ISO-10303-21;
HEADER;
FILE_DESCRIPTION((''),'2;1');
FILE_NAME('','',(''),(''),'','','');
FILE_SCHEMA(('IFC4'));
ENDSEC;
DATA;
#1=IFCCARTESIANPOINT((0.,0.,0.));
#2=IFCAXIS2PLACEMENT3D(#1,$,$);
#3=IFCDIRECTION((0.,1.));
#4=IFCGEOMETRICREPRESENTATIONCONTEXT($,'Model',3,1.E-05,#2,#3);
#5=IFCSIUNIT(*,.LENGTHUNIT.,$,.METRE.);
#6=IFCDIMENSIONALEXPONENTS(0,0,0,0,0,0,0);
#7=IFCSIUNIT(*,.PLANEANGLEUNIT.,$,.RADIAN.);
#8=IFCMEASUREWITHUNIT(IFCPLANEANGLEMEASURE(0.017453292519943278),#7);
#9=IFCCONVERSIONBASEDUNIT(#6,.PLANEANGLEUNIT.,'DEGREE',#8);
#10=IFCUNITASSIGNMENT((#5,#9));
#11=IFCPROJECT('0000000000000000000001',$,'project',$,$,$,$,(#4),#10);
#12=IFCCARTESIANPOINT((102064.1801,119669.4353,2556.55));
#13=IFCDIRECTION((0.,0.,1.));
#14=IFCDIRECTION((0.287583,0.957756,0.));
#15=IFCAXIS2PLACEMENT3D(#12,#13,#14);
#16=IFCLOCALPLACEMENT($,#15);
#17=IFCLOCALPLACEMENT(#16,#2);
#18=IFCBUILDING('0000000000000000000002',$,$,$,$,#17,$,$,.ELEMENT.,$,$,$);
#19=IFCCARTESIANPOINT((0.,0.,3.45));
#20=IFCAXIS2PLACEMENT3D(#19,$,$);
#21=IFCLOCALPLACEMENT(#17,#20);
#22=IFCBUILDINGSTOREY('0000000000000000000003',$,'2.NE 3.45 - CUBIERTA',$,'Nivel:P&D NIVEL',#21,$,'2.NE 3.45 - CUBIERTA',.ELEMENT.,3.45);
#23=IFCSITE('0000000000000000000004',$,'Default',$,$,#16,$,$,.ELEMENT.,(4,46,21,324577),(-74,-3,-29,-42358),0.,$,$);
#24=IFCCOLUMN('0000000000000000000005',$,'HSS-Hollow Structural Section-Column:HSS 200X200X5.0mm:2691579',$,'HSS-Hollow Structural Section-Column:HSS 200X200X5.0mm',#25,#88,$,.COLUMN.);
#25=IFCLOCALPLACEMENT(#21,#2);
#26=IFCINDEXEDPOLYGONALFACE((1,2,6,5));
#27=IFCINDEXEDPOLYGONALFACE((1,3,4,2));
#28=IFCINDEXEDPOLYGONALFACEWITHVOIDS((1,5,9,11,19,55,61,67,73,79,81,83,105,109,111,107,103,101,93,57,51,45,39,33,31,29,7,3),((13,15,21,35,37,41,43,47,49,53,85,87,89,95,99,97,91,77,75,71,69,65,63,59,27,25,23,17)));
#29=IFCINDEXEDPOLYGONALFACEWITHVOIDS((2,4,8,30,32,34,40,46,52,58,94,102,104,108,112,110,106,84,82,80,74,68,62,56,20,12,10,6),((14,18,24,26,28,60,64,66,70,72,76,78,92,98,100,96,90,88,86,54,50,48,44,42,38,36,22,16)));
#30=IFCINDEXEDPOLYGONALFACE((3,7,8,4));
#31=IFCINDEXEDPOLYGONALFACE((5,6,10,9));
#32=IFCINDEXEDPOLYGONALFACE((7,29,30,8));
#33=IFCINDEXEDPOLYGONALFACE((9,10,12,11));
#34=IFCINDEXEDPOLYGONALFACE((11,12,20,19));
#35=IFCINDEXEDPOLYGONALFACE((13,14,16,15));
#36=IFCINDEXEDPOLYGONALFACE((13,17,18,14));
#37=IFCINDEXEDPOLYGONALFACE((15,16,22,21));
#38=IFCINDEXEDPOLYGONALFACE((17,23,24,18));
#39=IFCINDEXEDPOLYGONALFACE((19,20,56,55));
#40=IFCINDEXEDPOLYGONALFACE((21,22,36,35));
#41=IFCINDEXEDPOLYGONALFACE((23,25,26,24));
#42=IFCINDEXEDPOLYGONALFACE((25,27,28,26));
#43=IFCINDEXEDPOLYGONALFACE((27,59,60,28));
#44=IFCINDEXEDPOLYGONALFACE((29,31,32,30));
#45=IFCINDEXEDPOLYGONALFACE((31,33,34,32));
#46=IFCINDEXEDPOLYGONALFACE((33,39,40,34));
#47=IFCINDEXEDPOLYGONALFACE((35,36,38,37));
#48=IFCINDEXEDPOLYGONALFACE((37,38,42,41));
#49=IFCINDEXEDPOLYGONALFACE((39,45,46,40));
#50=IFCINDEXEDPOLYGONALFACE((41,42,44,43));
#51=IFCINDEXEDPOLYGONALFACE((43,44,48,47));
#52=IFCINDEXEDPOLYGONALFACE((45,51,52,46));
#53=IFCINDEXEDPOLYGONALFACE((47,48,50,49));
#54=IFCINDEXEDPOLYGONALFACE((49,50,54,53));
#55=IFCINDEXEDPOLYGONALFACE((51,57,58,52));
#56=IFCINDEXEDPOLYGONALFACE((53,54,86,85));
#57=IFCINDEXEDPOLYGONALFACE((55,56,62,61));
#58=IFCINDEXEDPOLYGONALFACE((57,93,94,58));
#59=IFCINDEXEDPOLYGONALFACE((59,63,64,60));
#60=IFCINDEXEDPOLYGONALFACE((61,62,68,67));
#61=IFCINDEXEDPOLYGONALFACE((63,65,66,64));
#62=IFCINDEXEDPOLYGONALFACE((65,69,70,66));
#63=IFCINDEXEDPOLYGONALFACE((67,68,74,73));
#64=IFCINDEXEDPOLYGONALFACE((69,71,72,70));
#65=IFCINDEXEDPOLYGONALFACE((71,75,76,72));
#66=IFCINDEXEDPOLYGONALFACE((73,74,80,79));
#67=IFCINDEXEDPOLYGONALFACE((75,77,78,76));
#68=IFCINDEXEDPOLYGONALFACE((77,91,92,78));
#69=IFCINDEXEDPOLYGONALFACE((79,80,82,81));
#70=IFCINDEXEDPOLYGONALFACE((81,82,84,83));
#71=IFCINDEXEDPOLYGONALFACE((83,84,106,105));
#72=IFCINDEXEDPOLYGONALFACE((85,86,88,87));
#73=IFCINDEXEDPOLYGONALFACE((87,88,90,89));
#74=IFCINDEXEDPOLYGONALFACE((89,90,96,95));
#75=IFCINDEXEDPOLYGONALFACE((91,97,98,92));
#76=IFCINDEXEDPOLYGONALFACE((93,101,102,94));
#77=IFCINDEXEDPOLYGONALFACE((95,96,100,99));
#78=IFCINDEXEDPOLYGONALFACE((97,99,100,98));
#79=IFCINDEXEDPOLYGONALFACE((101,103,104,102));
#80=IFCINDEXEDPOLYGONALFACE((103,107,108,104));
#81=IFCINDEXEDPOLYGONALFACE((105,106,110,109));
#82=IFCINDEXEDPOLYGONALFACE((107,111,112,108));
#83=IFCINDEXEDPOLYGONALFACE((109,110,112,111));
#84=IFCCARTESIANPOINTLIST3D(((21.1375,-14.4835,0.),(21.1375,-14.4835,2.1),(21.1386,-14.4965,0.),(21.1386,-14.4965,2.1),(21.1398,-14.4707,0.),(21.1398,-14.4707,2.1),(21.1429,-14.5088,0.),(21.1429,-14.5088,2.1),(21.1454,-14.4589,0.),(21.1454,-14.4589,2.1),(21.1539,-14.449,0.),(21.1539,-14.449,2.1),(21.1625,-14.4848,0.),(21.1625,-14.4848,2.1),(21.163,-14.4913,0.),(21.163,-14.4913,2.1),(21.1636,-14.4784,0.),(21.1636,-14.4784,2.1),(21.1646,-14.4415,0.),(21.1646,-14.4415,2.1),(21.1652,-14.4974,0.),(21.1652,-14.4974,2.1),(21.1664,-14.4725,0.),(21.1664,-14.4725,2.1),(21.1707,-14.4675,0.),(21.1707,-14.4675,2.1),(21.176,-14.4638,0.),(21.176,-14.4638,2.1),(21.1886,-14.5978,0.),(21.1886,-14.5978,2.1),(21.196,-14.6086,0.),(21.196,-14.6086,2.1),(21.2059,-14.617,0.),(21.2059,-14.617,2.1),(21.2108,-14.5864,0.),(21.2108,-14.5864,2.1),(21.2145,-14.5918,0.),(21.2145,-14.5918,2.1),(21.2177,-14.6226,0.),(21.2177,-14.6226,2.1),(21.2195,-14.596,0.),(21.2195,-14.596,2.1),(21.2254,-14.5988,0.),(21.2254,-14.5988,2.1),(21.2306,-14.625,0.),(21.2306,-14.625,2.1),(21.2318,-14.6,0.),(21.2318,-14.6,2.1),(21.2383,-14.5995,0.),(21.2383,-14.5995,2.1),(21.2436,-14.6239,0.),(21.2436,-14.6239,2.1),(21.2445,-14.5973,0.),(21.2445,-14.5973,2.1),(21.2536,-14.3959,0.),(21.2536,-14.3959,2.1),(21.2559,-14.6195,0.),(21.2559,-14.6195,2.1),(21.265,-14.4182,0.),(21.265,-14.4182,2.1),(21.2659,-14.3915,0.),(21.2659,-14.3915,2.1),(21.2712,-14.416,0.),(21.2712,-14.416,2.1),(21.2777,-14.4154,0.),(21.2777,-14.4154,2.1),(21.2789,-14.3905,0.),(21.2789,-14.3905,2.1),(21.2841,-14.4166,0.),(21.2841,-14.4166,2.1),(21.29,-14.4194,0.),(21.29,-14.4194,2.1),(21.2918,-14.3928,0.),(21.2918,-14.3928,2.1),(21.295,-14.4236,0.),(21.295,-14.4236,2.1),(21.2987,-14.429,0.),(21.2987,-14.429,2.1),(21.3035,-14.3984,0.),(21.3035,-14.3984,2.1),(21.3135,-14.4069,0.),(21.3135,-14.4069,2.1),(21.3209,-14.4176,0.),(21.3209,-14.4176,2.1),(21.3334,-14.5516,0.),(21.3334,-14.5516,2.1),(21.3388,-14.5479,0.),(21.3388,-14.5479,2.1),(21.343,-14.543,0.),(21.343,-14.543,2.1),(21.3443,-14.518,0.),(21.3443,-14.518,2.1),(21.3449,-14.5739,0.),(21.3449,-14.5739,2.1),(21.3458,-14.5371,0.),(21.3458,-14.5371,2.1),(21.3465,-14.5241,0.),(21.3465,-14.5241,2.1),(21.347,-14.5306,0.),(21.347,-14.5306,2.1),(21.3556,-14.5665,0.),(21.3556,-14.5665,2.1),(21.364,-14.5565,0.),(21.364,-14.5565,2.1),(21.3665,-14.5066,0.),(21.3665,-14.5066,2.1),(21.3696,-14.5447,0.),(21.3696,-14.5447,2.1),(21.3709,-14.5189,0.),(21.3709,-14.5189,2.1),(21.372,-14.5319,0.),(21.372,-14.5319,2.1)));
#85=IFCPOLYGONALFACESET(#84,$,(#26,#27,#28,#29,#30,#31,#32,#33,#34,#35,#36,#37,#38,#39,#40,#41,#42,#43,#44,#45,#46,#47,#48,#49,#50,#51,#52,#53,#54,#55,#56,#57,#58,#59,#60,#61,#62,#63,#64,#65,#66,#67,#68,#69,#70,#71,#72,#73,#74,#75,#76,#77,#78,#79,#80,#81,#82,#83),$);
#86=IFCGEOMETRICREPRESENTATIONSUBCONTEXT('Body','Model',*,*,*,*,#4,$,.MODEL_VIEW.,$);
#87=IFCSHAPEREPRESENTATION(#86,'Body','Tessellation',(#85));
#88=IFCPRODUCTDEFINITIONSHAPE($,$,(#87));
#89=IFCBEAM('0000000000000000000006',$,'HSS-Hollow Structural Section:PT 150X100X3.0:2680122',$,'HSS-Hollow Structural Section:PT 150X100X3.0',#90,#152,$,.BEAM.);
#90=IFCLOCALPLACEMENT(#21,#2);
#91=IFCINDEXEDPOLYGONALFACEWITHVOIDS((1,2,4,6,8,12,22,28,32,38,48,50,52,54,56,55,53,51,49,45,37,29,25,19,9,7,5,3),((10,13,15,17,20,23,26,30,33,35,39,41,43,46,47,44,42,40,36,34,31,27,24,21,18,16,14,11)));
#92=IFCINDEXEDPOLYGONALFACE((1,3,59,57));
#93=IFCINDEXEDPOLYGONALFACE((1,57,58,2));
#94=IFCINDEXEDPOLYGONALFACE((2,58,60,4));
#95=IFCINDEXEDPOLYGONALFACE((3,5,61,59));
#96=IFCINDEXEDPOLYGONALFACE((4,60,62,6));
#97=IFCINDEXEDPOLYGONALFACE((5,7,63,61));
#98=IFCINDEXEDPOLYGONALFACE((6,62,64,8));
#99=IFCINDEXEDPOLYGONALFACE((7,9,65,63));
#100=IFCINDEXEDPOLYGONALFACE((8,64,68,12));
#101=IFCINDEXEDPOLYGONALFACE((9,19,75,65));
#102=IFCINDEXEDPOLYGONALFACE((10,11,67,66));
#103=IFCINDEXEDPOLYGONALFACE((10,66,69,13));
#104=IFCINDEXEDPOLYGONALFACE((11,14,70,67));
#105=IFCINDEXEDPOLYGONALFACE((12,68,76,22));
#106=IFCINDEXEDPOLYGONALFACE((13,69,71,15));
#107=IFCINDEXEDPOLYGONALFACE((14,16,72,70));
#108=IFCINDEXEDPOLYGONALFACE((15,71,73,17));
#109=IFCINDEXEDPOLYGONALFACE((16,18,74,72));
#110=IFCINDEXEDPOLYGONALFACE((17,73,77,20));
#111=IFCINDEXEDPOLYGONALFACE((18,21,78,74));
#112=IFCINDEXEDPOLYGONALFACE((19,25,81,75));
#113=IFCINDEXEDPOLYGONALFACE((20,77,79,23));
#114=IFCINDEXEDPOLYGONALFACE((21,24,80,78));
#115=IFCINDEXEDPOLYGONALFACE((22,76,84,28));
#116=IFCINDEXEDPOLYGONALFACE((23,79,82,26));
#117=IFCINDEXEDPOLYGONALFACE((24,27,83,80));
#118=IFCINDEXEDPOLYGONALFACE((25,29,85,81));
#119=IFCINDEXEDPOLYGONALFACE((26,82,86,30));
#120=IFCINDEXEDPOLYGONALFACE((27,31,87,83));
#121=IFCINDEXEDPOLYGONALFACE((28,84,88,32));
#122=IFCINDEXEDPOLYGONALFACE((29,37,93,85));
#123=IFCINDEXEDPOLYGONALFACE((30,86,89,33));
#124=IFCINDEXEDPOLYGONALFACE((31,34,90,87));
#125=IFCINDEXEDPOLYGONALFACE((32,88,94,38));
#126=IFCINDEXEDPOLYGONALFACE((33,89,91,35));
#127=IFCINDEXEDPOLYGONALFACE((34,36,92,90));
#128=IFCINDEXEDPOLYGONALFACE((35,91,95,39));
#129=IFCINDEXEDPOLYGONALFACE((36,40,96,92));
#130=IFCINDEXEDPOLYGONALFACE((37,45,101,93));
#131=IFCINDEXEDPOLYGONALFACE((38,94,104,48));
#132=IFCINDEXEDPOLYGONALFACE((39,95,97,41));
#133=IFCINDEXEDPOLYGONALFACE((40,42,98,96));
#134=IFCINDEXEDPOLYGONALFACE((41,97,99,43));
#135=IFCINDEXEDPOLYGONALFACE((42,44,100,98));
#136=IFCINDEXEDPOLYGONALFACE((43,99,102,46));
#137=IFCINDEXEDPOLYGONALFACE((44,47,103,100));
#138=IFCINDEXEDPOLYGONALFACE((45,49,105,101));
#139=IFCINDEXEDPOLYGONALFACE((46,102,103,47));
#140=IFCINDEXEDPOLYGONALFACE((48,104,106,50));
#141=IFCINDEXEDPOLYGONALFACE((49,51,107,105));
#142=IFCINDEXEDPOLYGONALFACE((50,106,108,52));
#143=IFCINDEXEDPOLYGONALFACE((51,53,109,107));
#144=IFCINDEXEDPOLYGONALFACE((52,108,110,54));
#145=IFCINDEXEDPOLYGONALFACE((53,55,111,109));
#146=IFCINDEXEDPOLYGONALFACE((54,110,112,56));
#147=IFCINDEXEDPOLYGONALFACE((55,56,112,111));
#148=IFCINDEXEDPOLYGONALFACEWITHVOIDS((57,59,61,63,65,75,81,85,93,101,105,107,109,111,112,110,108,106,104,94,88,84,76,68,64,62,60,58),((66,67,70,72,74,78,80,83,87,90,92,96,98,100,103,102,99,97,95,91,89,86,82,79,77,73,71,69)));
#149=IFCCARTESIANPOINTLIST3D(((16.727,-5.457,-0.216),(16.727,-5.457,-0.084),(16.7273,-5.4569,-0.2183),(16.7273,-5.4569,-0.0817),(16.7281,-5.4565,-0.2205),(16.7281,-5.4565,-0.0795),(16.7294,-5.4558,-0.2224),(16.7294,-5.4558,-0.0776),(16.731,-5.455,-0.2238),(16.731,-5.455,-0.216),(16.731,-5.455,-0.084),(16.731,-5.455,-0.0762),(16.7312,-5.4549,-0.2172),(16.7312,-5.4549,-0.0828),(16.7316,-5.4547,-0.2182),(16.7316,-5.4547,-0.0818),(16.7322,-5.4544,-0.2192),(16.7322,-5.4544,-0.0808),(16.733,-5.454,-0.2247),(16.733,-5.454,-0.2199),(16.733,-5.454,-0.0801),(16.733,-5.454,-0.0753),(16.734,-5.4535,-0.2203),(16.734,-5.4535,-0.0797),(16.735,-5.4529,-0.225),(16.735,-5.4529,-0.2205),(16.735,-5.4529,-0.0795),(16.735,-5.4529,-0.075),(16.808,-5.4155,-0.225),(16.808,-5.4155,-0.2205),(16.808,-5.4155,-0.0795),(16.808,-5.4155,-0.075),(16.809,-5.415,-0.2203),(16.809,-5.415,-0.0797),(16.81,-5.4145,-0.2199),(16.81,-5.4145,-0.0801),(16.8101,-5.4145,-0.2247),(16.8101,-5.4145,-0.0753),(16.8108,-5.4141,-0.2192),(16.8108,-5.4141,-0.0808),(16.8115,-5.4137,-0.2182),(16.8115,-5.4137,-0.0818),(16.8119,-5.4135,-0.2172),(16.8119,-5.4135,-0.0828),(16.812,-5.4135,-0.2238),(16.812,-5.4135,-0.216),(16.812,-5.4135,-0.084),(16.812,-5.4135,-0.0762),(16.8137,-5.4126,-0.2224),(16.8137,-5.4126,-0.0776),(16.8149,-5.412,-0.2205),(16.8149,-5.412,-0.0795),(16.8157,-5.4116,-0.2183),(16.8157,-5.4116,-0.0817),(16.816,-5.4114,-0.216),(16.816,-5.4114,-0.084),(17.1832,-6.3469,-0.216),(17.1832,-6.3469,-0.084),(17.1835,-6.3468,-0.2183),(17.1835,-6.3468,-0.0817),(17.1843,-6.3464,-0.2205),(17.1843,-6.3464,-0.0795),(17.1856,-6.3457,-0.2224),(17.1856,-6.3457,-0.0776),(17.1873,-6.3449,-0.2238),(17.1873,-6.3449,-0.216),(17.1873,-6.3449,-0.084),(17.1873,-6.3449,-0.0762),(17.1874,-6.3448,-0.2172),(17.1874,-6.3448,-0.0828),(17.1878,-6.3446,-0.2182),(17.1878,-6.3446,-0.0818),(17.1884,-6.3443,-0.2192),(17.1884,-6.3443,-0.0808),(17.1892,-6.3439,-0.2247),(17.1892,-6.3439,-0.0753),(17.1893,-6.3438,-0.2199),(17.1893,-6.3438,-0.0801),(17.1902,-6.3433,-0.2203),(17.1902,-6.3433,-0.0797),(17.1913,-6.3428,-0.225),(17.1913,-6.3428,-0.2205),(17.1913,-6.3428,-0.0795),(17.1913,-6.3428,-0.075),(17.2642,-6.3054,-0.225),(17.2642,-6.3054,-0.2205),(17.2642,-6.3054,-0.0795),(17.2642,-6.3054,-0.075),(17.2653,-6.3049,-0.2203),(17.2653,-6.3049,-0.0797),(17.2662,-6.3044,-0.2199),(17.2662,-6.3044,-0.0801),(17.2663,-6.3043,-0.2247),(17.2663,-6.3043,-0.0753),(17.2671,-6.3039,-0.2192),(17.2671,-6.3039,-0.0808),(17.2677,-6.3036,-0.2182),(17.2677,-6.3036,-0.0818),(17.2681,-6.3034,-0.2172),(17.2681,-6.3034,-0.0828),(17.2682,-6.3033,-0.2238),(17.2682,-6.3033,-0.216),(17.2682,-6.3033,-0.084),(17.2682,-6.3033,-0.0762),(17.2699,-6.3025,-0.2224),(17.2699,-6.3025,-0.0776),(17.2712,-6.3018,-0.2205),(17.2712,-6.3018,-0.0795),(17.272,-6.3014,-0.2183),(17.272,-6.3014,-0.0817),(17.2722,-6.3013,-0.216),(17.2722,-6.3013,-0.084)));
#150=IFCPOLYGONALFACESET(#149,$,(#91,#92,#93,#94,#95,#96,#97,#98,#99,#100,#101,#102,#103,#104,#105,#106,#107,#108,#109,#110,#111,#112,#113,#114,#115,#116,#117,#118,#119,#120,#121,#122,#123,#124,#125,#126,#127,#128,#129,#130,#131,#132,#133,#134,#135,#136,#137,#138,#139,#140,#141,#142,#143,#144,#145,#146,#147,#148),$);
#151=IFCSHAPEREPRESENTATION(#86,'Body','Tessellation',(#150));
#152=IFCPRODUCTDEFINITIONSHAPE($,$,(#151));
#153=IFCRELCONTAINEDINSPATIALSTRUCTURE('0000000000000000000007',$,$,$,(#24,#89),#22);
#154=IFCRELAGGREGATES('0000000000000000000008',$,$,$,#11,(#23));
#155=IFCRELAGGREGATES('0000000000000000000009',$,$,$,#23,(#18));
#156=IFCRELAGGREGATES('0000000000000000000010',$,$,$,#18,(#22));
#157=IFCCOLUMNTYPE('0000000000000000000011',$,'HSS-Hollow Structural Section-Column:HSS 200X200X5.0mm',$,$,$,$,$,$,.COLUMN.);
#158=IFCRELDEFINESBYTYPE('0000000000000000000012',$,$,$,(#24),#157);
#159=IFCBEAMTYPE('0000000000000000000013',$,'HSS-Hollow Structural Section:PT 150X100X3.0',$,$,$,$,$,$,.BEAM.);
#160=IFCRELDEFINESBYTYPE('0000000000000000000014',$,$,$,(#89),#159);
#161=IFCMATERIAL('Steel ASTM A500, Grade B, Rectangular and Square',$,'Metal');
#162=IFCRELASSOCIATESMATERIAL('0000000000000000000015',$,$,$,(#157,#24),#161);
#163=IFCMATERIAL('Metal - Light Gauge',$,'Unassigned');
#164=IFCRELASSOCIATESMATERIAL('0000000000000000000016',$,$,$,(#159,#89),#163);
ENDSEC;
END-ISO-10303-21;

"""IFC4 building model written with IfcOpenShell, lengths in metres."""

from ifc_helpers import new_model, entity, si_unit, converted_unit, direction, frame, origin, place, context, subcontext, project, spatial, line, arc, indexed_curve, outline, extrude, source, transform, mapped, material, type_object, type_shapes, element, save


model = new_model("IFC4")

# Units and contexts
model_context = context("Model", 3, precision=1e-05, world=origin(), true_north=direction((0.0, 1.0)))
body_context = subcontext(model_context, "Body", "Model", "MODEL_VIEW")
ifc_project = project(units=[si_unit("LENGTHUNIT", "METRE"), converted_unit("PLANEANGLEUNIT", "DEGREE", entity("IfcPlaneAngleMeasure", 0.017453292519943278), si_unit("PLANEANGLEUNIT", "RADIAN"), dimensions=[0, 0, 0, 0, 0, 0, 0])], contexts=[model_context])

# Site, building, storey
site_placement = place(None, frame((102064.1801, 119669.4353, 2556.55), z_axis=(0.0, 0.0, 1.0), x_axis=(0.287583, 0.957756, 0.0)))
site = spatial("IfcSite", under=ifc_project, at=site_placement, Name="Default", CompositionType="ELEMENT", RefLatitude=(4, 46, 21, 324577), RefLongitude=(-74, -3, -29, -42358), RefElevation=0.0)
building_placement = place(site_placement, origin())
building = spatial("IfcBuilding", under=site, at=building_placement, CompositionType="ELEMENT")
storey_placement = place(building_placement, frame((0.0, 0.0, 3.45)))
storey = spatial("IfcBuildingStorey", under=building, at=storey_placement, Name="2.NE 3.45 - CUBIERTA", ObjectType="Nivel:P&D NIVEL", LongName="2.NE 3.45 - CUBIERTA", CompositionType="ELEMENT", Elevation=3.45)

# Column
ifc_material_1 = material(Name="Steel ASTM A500, Grade B, Rectangular and Square", Category="Metal")
column_type_1 = type_object("IfcColumnType", Name="HSS-Hollow Structural Section-Column:HSS 200X200X5.0mm", PredefinedType="COLUMN", material=ifc_material_1)
shared_shape_1 = source(origin(), body_context, "Body", "SweptSolid", [
    extrude(outline(indexed_curve([(-0.05, -0.1), (0.05, -0.1), (0.0854, -0.0854), (0.1, -0.05), (0.1, 0.05), (0.0854, 0.0854), (0.05, 0.1), (-0.05, 0.1), (-0.0854, 0.0854), (-0.1, 0.05), (-0.1, -0.05), (-0.0854, -0.0854)], segments=[line(1, 2), arc(2, 3, 4), line(4, 5), arc(5, 6, 7), line(7, 8), arc(8, 9, 10), line(10, 11), arc(11, 12, 1)], self_intersect=False), holes=[indexed_curve([(-0.05, -0.075), (-0.0677, -0.0677), (-0.075, -0.05), (-0.075, 0.05), (-0.0677, 0.0677), (-0.05, 0.075), (0.05, 0.075), (0.0677, 0.0677), (0.075, 0.05), (0.075, -0.05), (0.0677, -0.0677), (0.05, -0.075)], segments=[arc(1, 2, 3), line(3, 4), arc(4, 5, 6), line(6, 7), arc(7, 8, 9), line(9, 10), arc(10, 11, 12), line(12, 1)], self_intersect=False)]), frame((0.0, 0.0, 3.45), z_axis=(0.0, 0.0, 1.0), x_axis=(-1.0, 0.0, 0.0)), (0.0, 0.0, 1.0), 2.1),
])
type_shapes(column_type_1, [shared_shape_1])
for number, where, z_axis, x_axis, name in (
    (1, (21.2547, -14.5077, -3.45), (0.0, 0.0, 1.0), (0.889869, 0.456217, 0.0), "HSS-Hollow Structural Section-Column:HSS 200X200X5.0mm:2691579"),
):
    element("IfcColumn", number, at=place(storey_placement, frame(where, z_axis=z_axis, x_axis=x_axis)), inside=storey, type_object=column_type_1, material=ifc_material_1, Name=name, ObjectType="HSS-Hollow Structural Section-Column:HSS 200X200X5.0mm", PredefinedType="COLUMN", context=body_context, shape_type="MappedRepresentation", body=[
        mapped(shared_shape_1, transform((0.0, 0.0, 0.0), scale=1.0)),
    ])

# Beam
ifc_material_2 = material(Name="Metal - Light Gauge", Category="Unassigned")
beam_type_1 = type_object("IfcBeamType", Name="HSS-Hollow Structural Section:PT 150X100X3.0", PredefinedType="BEAM", material=ifc_material_2)
shared_shape_2 = source(origin(), body_context, "Body", "SweptSolid", [
    extrude(outline(indexed_curve([(-0.05, -0.066), (-0.0474, -0.0724), (-0.041, -0.075), (0.041, -0.075), (0.0474, -0.0724), (0.05, -0.066), (0.05, 0.066), (0.0474, 0.0724), (0.041, 0.075), (-0.041, 0.075), (-0.0474, 0.0724), (-0.05, 0.066)], segments=[arc(1, 2, 3), line(3, 4), arc(4, 5, 6), line(6, 7), arc(7, 8, 9), line(9, 10), arc(10, 11, 12), line(12, 1)], self_intersect=False), holes=[indexed_curve([(0.041, -0.0705), (-0.041, -0.0705), (-0.0442, -0.0692), (-0.0455, -0.066), (-0.0455, 0.066), (-0.0442, 0.0692), (-0.041, 0.0705), (0.041, 0.0705), (0.0442, 0.0692), (0.0455, 0.066), (0.0455, -0.066), (0.0442, -0.0692)], segments=[line(1, 2), arc(2, 3, 4), line(4, 5), arc(5, 6, 7), line(7, 8), arc(8, 9, 10), line(10, 11), arc(11, 12, 1)], self_intersect=False)]), frame((-0.5, 0.0, 0.0), z_axis=(1.0, 0.0, 0.0), x_axis=(0.0, -1.0, 0.0)), (0.0, 0.0, 1.0), 1.0),
])
type_shapes(beam_type_1, [shared_shape_2])
beam_1_placement = place(storey_placement, frame((16.9996, -5.8792, -0.15), z_axis=(0.0, 0.0, 1.0), x_axis=(-0.456217, 0.889869, 0.0)))
element("IfcBeam", 2, at=beam_1_placement, inside=storey, type_object=beam_type_1, material=ifc_material_2, Name="HSS-Hollow Structural Section:PT 150X100X3.0:2680122", ObjectType="HSS-Hollow Structural Section:PT 150X100X3.0", PredefinedType="BEAM", context=body_context, shape_type="MappedRepresentation", body=[
    mapped(shared_shape_2, transform((0.0, 0.0, 0.0), scale=1.0)),
])

save(model, "model.ifc")
